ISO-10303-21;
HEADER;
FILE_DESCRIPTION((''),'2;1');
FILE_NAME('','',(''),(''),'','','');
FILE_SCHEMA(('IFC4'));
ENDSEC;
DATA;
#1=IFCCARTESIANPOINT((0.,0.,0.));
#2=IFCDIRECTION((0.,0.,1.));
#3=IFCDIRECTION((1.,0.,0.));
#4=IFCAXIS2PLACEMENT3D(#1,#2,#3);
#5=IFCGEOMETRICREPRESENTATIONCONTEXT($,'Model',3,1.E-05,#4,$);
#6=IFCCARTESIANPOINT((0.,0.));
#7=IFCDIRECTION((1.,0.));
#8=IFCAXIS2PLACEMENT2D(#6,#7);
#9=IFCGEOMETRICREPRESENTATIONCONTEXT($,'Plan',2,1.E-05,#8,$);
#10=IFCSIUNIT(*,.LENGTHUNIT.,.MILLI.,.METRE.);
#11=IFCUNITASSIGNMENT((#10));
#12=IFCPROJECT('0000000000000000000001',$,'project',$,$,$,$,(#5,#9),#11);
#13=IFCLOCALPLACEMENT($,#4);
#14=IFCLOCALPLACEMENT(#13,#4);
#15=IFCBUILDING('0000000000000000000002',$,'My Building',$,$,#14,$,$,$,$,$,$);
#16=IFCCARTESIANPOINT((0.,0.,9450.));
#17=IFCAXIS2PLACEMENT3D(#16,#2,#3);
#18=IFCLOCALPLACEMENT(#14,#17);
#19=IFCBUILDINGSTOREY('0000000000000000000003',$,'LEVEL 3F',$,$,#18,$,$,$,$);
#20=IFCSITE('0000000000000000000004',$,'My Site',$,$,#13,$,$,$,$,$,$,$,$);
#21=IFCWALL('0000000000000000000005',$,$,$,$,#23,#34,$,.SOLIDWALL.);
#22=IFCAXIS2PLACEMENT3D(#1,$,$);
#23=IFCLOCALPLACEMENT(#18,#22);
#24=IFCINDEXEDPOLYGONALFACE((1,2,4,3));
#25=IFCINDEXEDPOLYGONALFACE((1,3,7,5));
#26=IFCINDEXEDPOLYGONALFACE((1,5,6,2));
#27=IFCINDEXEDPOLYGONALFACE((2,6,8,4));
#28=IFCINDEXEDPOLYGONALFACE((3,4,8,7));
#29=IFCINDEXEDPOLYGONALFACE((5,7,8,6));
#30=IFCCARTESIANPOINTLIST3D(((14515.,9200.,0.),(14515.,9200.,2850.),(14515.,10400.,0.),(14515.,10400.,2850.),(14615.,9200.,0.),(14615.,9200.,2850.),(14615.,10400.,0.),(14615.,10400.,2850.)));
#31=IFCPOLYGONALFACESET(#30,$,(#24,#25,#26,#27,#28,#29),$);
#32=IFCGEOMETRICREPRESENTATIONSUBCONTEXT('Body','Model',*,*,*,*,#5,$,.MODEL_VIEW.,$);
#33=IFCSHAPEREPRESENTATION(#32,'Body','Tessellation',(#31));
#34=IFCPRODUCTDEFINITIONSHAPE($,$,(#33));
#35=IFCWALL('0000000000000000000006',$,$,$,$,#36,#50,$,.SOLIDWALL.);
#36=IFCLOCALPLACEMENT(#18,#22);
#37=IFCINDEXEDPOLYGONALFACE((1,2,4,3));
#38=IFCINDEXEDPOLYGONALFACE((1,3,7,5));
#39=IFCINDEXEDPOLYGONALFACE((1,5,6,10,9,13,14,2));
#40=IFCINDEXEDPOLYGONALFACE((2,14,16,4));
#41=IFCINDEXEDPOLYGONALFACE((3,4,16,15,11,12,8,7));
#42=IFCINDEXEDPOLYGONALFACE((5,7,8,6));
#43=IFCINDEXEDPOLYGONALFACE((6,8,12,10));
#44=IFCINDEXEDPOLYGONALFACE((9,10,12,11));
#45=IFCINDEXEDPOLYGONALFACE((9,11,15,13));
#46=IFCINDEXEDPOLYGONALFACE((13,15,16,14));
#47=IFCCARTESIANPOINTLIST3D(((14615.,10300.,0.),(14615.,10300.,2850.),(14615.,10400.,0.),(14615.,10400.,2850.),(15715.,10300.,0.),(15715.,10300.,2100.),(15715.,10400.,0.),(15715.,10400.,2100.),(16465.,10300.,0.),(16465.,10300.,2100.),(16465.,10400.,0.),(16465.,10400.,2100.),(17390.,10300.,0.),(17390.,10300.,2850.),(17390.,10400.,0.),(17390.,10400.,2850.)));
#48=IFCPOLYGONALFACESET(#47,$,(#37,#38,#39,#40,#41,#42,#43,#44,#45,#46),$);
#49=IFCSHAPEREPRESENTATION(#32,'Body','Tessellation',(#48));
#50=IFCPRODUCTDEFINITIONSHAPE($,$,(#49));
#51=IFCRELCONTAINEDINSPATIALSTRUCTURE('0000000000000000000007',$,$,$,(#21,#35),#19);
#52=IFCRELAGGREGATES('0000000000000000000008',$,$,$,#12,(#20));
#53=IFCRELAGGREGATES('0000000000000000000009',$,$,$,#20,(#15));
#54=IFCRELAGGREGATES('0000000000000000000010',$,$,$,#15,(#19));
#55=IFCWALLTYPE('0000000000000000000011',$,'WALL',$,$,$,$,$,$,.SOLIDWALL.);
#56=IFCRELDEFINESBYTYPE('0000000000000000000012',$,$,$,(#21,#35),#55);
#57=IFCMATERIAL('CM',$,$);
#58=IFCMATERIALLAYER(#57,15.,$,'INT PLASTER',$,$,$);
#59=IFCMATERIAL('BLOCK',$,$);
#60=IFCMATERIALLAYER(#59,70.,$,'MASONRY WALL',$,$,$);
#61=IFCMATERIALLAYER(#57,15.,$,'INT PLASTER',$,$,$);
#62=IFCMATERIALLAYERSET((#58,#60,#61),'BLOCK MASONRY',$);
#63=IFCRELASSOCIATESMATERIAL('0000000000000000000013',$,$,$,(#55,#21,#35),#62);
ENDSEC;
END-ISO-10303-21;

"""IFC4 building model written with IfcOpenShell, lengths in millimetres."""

from ifc_helpers import new_model, si_unit, frame, origin_with_axes, origin_2d_with_axis, place, context, subcontext, project, spatial, indexed_curve, outline, extrude, material, layer, layer_set, layer_usage, type_object, element, save


model = new_model("IFC4")

# Units and contexts
model_context = context("Model", 3, precision=1e-05, world=origin_with_axes())
plan_context = context("Plan", 2, precision=1e-05, world=origin_2d_with_axis())
body_context = subcontext(model_context, "Body", "Model", "MODEL_VIEW")
ifc_project = project(units=[si_unit("LENGTHUNIT", "METRE", prefix="MILLI")], contexts=[model_context, plan_context])

# Site, building, storey
site_placement = place(None, origin_with_axes())
site = spatial("IfcSite", under=ifc_project, at=site_placement, Name="My Site")
building_placement = place(site_placement, origin_with_axes())
building = spatial("IfcBuilding", under=site, at=building_placement, Name="My Building")
storey_placement = place(building_placement, frame((0.0, 0.0, 9450.0), z_axis=(0.0, 0.0, 1.0), x_axis=(1.0, 0.0, 0.0)))
storey = spatial("IfcBuildingStorey", under=building, at=storey_placement, Name="LEVEL 3F")

# Shared definitions
ifc_material_1 = material(Name="CM")
ifc_layer_1 = layer(ifc_material_1, 15.0, Name="INT PLASTER")
ifc_material_2 = material(Name="BLOCK")
ifc_layer_2 = layer(ifc_material_2, 70.0, Name="MASONRY WALL")
ifc_layer_3 = layer(ifc_material_1, 15.0, Name="INT PLASTER")
ifc_layer_set = layer_set([ifc_layer_1, ifc_layer_2, ifc_layer_3], Name="BLOCK MASONRY")
wall_type = type_object("IfcWallType", Name="WALL", PredefinedType="SOLIDWALL", material=ifc_layer_set)

# Wall
ifc_layer_usage_1 = layer_usage(ifc_layer_set, "AXIS2", "POSITIVE", 0.0)
wall_1_placement = place(storey_placement, frame((14615.0, 9200.0, 0.0), z_axis=(0.0, 0.0, 1.0), x_axis=(0.0, 1.0, 0.0)))
element("IfcWall", 1, at=wall_1_placement, inside=storey, type_object=wall_type, material=ifc_layer_usage_1, PredefinedType="SOLIDWALL", context=body_context, shape_type="SweptSolid", body=[
    extrude(outline(indexed_curve([(0.0, 0.0), (0.0, 100.0), (1200.0, 100.0), (1200.0, 0.0), (0.0, 0.0)], self_intersect=False)), origin_with_axes(), (0.0, 0.0, 1.0), 2850.0),
])

# Wall, opening
ifc_layer_usage_2 = layer_usage(ifc_layer_set, "AXIS2", "POSITIVE", 0.0)
wall_2_placement = place(storey_placement, frame((14615.0, 10400.0, 0.0), z_axis=(0.0, 0.0, 1.0), x_axis=(0.0, -1.0, 0.0)))
wall_2 = element("IfcWall", 2, at=wall_2_placement, inside=storey, type_object=wall_type, material=ifc_layer_usage_2, PredefinedType="SOLIDWALL", context=body_context, shape_type="SweptSolid", body=[
    extrude(outline(indexed_curve([(0.0, 0.0), (0.0, 2775.0), (100.0, 2775.0), (100.0, 0.0), (0.0, 0.0)], self_intersect=False)), origin_with_axes(), (0.0, 0.0, 1.0), 2850.0),
])
opening_1_placement = place(wall_2_placement, frame((0.0, 1850.0, 0.0), z_axis=(0.0, 0.0, 1.0), x_axis=(0.0, -1.0, 0.0)))
element("IfcOpeningElement", 3, at=opening_1_placement, cuts=wall_2, PredefinedType="OPENING", context=body_context, shape_type="SweptSolid", body=[
    extrude(outline(indexed_curve([(0.0, 0.0), (0.0, 400.0), (750.0, 400.0), (750.0, 0.0), (0.0, 0.0)], self_intersect=False)), frame((0.0, -100.0, 0.0), z_axis=(0.0, 0.0, 1.0), x_axis=(1.0, 0.0, 0.0)), (0.0, 0.0, 1.0), 2100.0),
])

save(model, "model.ifc")
